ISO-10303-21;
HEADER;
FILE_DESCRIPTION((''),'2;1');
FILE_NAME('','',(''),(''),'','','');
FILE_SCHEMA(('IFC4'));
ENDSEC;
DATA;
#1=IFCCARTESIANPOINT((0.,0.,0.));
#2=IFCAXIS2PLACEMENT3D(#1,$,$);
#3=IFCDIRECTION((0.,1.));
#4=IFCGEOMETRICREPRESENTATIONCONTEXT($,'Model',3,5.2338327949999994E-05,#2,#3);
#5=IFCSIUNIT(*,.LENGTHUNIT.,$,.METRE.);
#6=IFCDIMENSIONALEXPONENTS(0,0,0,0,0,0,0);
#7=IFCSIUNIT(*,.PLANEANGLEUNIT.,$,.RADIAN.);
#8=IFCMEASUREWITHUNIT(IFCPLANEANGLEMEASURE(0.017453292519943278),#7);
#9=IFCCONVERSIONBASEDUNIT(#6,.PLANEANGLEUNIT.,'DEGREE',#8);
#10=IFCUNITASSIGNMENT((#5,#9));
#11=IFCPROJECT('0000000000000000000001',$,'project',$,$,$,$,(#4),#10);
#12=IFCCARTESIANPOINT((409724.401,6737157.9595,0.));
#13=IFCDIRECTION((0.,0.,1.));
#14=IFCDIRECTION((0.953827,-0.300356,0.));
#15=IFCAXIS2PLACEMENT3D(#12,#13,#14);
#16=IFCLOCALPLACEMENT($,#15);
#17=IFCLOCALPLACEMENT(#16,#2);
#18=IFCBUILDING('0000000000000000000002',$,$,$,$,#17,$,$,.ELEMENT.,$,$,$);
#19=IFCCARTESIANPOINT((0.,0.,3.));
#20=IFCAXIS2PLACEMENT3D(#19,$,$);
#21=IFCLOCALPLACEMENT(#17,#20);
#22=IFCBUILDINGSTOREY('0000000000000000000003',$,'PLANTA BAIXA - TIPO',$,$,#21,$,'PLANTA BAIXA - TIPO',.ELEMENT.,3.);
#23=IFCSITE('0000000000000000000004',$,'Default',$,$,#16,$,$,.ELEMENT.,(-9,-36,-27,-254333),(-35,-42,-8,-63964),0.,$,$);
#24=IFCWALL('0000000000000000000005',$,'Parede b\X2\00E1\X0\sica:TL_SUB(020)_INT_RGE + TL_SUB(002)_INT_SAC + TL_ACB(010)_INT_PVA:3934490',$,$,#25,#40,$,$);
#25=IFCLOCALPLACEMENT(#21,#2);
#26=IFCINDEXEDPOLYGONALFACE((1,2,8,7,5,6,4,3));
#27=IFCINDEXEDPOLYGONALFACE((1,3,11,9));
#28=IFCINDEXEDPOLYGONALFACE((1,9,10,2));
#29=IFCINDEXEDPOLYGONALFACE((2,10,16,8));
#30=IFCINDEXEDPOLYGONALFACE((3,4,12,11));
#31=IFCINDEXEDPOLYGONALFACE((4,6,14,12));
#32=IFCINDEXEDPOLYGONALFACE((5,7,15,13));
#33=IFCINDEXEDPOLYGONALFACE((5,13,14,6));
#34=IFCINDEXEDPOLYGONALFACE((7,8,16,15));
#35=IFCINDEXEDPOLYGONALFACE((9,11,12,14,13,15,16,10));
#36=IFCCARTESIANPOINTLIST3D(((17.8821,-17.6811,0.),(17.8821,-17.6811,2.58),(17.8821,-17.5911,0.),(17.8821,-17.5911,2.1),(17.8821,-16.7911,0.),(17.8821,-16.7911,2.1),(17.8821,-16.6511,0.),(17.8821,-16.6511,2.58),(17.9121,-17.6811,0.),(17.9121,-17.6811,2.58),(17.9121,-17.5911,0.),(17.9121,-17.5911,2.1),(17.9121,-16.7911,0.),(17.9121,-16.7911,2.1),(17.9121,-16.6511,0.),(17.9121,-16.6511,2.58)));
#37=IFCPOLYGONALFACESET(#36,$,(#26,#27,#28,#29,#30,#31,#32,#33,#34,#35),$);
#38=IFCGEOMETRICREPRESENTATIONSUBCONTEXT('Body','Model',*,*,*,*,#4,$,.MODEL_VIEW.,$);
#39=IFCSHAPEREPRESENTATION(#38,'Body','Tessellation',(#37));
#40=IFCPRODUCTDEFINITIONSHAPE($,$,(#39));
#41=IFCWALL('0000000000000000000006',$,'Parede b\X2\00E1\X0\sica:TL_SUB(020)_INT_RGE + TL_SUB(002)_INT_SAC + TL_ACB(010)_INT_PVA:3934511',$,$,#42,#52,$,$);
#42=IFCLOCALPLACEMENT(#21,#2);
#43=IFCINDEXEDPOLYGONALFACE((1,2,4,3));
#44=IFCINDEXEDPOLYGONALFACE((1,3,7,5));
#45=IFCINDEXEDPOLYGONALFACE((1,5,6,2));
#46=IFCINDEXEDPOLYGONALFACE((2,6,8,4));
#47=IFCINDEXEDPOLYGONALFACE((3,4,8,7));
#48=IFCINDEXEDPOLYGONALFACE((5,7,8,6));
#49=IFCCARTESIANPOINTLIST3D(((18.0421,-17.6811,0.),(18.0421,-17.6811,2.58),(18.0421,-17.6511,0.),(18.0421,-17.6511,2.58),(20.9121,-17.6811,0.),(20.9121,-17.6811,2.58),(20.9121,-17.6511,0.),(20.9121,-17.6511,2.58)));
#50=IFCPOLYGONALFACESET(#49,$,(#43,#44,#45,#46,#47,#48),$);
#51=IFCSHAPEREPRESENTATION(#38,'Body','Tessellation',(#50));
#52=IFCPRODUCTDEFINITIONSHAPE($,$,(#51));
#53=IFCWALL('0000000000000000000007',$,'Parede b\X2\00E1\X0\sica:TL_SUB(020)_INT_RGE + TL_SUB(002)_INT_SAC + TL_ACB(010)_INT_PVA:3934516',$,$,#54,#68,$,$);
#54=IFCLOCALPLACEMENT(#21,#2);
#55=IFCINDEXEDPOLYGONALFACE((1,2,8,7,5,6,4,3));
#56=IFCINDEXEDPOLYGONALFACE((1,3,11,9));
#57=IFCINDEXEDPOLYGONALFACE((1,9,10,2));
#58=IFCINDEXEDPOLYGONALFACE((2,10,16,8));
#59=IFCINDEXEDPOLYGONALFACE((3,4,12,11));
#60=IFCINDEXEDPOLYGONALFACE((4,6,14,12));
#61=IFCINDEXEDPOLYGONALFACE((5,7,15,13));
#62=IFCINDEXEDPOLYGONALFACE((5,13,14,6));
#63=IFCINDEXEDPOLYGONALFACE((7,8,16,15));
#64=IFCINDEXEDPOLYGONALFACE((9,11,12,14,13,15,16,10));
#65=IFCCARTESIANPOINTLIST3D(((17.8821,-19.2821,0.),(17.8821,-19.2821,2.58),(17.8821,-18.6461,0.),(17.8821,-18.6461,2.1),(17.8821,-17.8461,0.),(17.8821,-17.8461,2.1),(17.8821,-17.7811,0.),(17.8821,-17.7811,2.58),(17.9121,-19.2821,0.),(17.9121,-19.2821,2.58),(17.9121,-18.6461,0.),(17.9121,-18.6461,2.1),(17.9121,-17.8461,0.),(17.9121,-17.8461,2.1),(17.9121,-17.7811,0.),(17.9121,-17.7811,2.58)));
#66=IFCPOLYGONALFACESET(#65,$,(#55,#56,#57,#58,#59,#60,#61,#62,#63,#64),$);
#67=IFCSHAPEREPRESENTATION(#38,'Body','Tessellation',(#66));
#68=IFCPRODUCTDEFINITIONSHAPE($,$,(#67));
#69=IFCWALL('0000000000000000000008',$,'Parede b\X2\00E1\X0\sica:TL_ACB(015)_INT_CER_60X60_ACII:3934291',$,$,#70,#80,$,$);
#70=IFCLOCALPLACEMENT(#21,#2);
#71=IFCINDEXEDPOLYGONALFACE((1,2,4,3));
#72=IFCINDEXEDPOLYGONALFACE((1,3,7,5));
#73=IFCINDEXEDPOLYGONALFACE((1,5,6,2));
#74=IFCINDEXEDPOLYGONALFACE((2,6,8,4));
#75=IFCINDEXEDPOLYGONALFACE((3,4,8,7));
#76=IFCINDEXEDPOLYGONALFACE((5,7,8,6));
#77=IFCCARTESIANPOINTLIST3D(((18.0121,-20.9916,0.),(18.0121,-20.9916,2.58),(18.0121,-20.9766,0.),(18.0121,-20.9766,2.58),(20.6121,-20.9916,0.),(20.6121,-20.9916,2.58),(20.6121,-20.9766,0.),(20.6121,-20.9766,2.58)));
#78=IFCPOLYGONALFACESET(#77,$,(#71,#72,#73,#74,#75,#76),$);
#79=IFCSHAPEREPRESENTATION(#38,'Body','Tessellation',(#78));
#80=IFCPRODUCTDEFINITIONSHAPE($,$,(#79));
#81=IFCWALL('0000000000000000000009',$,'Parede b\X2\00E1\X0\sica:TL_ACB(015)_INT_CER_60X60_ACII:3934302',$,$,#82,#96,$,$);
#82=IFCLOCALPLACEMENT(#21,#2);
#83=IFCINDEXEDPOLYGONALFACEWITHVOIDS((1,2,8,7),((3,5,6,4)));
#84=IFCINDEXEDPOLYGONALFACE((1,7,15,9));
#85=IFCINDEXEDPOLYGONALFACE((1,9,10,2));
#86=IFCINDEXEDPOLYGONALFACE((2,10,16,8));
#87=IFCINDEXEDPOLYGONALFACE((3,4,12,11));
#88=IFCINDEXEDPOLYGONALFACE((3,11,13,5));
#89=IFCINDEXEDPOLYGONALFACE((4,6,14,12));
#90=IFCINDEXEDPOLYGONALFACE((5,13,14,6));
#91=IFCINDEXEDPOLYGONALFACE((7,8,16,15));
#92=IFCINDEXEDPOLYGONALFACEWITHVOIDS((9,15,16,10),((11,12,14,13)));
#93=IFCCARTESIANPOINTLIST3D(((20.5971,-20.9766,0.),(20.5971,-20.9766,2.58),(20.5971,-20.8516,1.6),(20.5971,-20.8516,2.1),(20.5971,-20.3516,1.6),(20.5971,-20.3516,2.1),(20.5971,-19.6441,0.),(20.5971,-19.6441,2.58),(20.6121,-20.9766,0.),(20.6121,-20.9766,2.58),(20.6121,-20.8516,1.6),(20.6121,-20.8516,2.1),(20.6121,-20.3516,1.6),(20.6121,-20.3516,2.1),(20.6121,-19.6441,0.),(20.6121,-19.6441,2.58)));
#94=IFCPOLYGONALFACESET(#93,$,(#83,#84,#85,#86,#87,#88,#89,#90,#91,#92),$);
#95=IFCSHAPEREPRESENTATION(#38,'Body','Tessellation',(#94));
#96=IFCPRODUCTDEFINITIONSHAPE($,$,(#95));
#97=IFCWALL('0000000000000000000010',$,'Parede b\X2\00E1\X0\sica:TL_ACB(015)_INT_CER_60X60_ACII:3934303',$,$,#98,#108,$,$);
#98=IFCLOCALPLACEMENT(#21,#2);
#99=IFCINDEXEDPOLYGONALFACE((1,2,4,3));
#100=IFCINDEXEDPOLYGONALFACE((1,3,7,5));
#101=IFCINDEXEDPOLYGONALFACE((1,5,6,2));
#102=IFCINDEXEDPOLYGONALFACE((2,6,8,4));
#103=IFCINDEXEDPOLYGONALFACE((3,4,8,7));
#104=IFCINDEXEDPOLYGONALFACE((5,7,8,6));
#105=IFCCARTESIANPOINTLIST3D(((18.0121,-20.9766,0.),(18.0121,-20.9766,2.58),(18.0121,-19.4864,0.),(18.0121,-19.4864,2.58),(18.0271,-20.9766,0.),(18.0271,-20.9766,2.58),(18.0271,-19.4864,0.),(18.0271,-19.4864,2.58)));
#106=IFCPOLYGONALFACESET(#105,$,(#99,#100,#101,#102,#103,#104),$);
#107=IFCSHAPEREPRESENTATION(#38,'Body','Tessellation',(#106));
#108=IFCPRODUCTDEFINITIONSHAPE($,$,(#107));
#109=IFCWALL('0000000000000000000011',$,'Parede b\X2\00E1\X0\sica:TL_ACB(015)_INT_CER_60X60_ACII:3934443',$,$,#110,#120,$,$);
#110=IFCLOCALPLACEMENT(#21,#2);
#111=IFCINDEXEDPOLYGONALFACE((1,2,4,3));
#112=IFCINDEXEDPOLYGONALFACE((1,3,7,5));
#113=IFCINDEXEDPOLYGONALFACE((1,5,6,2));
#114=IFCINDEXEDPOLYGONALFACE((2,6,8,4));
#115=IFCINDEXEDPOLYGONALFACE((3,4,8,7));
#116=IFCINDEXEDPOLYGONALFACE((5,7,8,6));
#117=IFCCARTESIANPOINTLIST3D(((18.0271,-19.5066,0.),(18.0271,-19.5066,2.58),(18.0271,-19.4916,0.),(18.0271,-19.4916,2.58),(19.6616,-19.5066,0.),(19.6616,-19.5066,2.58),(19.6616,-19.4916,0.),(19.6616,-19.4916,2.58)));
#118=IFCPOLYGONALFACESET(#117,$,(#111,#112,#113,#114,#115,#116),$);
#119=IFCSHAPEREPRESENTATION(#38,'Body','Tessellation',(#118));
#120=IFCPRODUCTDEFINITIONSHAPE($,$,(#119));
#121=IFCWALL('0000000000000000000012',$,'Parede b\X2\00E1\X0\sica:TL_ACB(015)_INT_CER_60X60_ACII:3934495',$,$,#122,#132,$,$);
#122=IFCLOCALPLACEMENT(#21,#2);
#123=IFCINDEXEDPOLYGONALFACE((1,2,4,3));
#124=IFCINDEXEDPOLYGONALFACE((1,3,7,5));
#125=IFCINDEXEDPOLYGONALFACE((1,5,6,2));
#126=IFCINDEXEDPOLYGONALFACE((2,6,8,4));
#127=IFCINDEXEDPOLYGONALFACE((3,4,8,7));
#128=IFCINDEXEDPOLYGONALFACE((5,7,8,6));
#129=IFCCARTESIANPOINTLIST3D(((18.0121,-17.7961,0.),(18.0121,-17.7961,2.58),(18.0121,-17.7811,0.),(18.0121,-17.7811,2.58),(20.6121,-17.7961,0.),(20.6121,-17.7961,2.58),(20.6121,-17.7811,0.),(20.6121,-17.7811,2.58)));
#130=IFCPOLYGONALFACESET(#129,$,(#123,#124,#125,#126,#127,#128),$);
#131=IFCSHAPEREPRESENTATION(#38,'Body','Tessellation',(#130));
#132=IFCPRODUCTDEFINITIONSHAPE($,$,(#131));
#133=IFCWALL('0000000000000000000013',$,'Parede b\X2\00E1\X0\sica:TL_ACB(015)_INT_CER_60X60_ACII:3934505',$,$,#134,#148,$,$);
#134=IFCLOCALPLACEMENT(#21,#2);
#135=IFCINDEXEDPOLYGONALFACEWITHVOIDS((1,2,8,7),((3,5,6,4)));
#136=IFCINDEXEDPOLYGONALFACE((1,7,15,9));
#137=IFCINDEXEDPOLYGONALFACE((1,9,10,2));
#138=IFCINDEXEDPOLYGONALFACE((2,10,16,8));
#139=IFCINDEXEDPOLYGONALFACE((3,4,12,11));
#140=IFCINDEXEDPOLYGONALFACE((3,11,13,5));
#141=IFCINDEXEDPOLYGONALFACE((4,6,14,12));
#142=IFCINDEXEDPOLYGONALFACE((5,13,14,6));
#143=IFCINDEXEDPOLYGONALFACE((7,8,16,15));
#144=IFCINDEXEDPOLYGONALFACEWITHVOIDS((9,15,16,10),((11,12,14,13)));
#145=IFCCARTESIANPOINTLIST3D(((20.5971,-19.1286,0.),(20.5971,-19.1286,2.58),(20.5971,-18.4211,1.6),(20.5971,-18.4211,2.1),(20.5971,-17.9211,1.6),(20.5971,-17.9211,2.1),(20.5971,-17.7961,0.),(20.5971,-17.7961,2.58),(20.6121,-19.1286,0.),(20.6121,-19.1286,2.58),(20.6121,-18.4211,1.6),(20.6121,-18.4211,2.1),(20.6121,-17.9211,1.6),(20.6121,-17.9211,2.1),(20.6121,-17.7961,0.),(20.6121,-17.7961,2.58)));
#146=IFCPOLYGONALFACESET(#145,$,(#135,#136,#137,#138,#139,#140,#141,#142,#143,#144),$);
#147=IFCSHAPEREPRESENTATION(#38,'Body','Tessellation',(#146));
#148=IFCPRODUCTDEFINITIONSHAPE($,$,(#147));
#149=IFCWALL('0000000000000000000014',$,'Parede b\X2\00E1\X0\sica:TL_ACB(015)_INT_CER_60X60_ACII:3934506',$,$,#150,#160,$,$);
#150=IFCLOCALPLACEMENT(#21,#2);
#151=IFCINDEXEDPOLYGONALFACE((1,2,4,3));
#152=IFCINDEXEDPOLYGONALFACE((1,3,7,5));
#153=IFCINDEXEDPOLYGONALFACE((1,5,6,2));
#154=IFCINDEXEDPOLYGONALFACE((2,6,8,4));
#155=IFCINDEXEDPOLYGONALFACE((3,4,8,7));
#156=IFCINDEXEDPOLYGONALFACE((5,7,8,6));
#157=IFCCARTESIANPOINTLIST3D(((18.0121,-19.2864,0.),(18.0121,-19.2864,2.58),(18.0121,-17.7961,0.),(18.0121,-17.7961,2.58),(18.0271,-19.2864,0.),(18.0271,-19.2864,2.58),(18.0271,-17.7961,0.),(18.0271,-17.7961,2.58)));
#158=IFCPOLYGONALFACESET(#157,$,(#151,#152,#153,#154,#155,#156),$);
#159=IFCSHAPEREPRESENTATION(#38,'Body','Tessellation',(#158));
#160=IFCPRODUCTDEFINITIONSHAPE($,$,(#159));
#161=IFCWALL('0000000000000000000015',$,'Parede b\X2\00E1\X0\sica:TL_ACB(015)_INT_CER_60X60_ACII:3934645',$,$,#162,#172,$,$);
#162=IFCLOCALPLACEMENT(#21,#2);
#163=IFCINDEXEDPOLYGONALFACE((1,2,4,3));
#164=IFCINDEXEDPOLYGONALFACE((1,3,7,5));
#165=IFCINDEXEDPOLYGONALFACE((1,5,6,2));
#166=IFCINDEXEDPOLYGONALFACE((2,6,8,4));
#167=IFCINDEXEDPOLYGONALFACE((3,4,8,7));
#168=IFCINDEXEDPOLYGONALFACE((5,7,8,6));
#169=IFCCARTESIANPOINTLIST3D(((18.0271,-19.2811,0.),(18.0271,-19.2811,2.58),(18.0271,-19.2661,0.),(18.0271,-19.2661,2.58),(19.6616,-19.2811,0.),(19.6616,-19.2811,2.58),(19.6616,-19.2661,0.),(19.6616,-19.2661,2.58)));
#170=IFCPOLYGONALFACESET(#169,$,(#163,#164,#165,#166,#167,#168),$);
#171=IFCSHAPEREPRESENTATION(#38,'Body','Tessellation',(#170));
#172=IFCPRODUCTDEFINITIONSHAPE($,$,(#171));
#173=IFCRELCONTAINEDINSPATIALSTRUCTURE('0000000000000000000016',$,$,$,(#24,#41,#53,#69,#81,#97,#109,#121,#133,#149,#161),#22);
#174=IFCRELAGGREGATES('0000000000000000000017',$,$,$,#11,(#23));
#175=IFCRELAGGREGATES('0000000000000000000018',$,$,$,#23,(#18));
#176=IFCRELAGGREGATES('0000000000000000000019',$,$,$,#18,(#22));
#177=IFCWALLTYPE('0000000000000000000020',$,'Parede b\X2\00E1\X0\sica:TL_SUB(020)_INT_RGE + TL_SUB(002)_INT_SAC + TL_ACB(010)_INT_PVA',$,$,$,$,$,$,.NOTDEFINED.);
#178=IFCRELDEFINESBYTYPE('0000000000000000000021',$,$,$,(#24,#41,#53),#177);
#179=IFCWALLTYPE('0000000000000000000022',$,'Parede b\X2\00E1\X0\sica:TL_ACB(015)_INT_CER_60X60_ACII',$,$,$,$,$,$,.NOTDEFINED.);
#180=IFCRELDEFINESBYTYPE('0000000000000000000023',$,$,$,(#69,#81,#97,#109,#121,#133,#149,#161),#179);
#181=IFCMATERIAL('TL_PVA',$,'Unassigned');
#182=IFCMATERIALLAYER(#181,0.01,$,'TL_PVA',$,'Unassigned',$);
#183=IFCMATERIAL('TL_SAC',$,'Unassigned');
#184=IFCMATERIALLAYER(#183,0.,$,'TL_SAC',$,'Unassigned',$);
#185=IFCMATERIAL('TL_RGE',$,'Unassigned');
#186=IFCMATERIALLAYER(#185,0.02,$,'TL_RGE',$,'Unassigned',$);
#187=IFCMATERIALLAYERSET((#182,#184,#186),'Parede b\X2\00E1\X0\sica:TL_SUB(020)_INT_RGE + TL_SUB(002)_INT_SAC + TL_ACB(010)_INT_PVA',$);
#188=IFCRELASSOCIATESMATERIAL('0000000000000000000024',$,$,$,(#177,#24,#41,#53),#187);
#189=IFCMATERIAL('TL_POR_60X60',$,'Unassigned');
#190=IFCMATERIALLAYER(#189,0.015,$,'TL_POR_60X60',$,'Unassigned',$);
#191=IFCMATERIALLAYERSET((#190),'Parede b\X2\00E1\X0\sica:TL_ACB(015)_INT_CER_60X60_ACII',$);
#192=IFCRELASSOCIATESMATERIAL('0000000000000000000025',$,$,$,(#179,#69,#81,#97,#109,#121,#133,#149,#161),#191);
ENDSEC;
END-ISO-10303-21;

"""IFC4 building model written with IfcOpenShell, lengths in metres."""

from ifc_helpers import new_model, entity, si_unit, converted_unit, direction, frame, frame_2d, origin, place, context, subcontext, project, spatial, rectangle, extrude, material, layer, layer_set, layer_usage, type_object, element, save


model = new_model("IFC4")

# Units and contexts
model_context = context("Model", 3, precision=5.2338327949999994e-05, world=origin(), true_north=direction((0.0, 1.0)))
body_context = subcontext(model_context, "Body", "Model", "MODEL_VIEW")
ifc_project = project(units=[si_unit("LENGTHUNIT", "METRE"), converted_unit("PLANEANGLEUNIT", "DEGREE", entity("IfcPlaneAngleMeasure", 0.017453292519943278), si_unit("PLANEANGLEUNIT", "RADIAN"), dimensions=[0, 0, 0, 0, 0, 0, 0])], contexts=[model_context])

# Site, building, storey
site_placement = place(None, frame((409724.401, 6737157.9595, 0.0), z_axis=(0.0, 0.0, 1.0), x_axis=(0.953827, -0.300356, 0.0)))
site = spatial("IfcSite", under=ifc_project, at=site_placement, Name="Default", CompositionType="ELEMENT", RefLatitude=(-9, -36, -27, -254333), RefLongitude=(-35, -42, -8, -63964), RefElevation=0.0)
building_placement = place(site_placement, origin())
building = spatial("IfcBuilding", under=site, at=building_placement, CompositionType="ELEMENT")
storey_placement = place(building_placement, frame((0.0, 0.0, 3.0)))
storey = spatial("IfcBuildingStorey", under=building, at=storey_placement, Name="PLANTA BAIXA - TIPO", LongName="PLANTA BAIXA - TIPO", CompositionType="ELEMENT", Elevation=3.0)

# Wall, opening
ifc_material_1 = material(Name="TL_PVA", Category="Unassigned")
ifc_layer_1 = layer(ifc_material_1, 0.01, Name="TL_PVA", Category="Unassigned")
ifc_material_2 = material(Name="TL_SAC", Category="Unassigned")
ifc_layer_2 = layer(ifc_material_2, 0.0, Name="TL_SAC", Category="Unassigned")
ifc_material_3 = material(Name="TL_RGE", Category="Unassigned")
ifc_layer_3 = layer(ifc_material_3, 0.02, Name="TL_RGE", Category="Unassigned")
ifc_layer_set_1 = layer_set([ifc_layer_1, ifc_layer_2, ifc_layer_3], Name="Parede básica:TL_SUB(020)_INT_RGE + TL_SUB(002)_INT_SAC + TL_ACB(010)_INT_PVA")
ifc_layer_usage_1 = layer_usage(ifc_layer_set_1, "AXIS2", "NEGATIVE", 0.015)
wall_type_1 = type_object("IfcWallType", Name="Parede básica:TL_SUB(020)_INT_RGE + TL_SUB(002)_INT_SAC + TL_ACB(010)_INT_PVA", PredefinedType="NOTDEFINED", material=ifc_layer_set_1)
wall_1_placement = place(storey_placement, frame((17.8971, -17.6811, 0.0), z_axis=(0.0, 0.0, 1.0), x_axis=(0.0, 1.0, 0.0)))
wall_1 = element("IfcWall", 1, at=wall_1_placement, inside=storey, type_object=wall_type_1, material=ifc_layer_usage_1, Name="Parede básica:TL_SUB(020)_INT_RGE + TL_SUB(002)_INT_SAC + TL_ACB(010)_INT_PVA:3934490", context=body_context, shape_type="SweptSolid", body=[
    extrude(rectangle(XDim=1.03, YDim=0.03, at=frame_2d((0.515, 0.0), x_axis=(-1.0, 0.0))), origin(), (0.0, 0.0, 1.0), 2.58),
])
opening_1_placement = place(wall_1_placement, frame((17.6811, 17.8971, 0.0)))
element("IfcOpeningElement", 2, at=opening_1_placement, cuts=wall_1, PredefinedType="OPENING", context=body_context, shape_type="SweptSolid", body=[
    extrude(rectangle(XDim=2.1, YDim=0.8, at=frame_2d((0.0, 0.0), x_axis=(1.0, 0.0))), frame((-17.1911, -19.4361, 1.05), z_axis=(0.0, 1.0, 0.0), x_axis=(0.0, 0.0, 1.0)), (0.0, 0.0, 1.0), 3.048),
])

# Wall
ifc_layer_usage_2 = layer_usage(ifc_layer_set_1, "AXIS2", "POSITIVE", -0.015)
wall_2_placement = place(storey_placement, frame((20.9121, -17.6661, 0.0), z_axis=(0.0, 0.0, 1.0), x_axis=(-1.0, 0.0, 0.0)))
element("IfcWall", 3, at=wall_2_placement, inside=storey, type_object=wall_type_1, material=ifc_layer_usage_2, Name="Parede básica:TL_SUB(020)_INT_RGE + TL_SUB(002)_INT_SAC + TL_ACB(010)_INT_PVA:3934511", context=body_context, shape_type="SweptSolid", body=[
    extrude(rectangle(XDim=2.87, YDim=0.03, at=frame_2d((1.435, 0.0), x_axis=(-1.0, 0.0))), origin(), (0.0, 0.0, 1.0), 2.58),
])

# Wall, opening
ifc_layer_usage_3 = layer_usage(ifc_layer_set_1, "AXIS2", "POSITIVE", -0.015)
wall_3_placement = place(storey_placement, frame((17.8971, -17.7811, 0.0), z_axis=(0.0, 0.0, 1.0), x_axis=(0.0, -1.0, 0.0)))
wall_3 = element("IfcWall", 4, at=wall_3_placement, inside=storey, type_object=wall_type_1, material=ifc_layer_usage_3, Name="Parede básica:TL_SUB(020)_INT_RGE + TL_SUB(002)_INT_SAC + TL_ACB(010)_INT_PVA:3934516", context=body_context, shape_type="SweptSolid", body=[
    extrude(rectangle(XDim=1.501, YDim=0.03, at=frame_2d((0.7505, 0.0), x_axis=(-1.0, 0.0))), origin(), (0.0, 0.0, 1.0), 2.58),
])
opening_2_placement = place(wall_3_placement, frame((0.065, -0.015, 0.0)))
element("IfcOpeningElement", 5, at=opening_2_placement, cuts=wall_3, PredefinedType="OPENING", context=body_context, shape_type="SweptSolid", body=[
    extrude(rectangle(XDim=2.1, YDim=0.8, at=frame_2d((1.05, 0.4), x_axis=(1.0, 0.0))), frame((0.0, 0.0, 0.0), z_axis=(0.0, 1.0, 0.0), x_axis=(0.0, 0.0, 1.0)), (0.0, 0.0, 1.0), 0.03),
])

# Wall
ifc_material_4 = material(Name="TL_POR_60X60", Category="Unassigned")
ifc_layer_4 = layer(ifc_material_4, 0.015, Name="TL_POR_60X60", Category="Unassigned")
ifc_layer_set_2 = layer_set([ifc_layer_4], Name="Parede básica:TL_ACB(015)_INT_CER_60X60_ACII")
ifc_layer_usage_4 = layer_usage(ifc_layer_set_2, "AXIS2", "POSITIVE", -0.0075)
wall_type_2 = type_object("IfcWallType", Name="Parede básica:TL_ACB(015)_INT_CER_60X60_ACII", PredefinedType="NOTDEFINED", material=ifc_layer_set_2)
wall_4_placement = place(storey_placement, frame((20.6121, -20.9841, 0.0), z_axis=(0.0, 0.0, 1.0), x_axis=(-1.0, 0.0, 0.0)))
element("IfcWall", 6, at=wall_4_placement, inside=storey, type_object=wall_type_2, material=ifc_layer_usage_4, Name="Parede básica:TL_ACB(015)_INT_CER_60X60_ACII:3934291", context=body_context, shape_type="SweptSolid", body=[
    extrude(rectangle(XDim=2.6, YDim=0.015, at=frame_2d((1.3, 0.0), x_axis=(-1.0, 0.0))), origin(), (0.0, 0.0, 1.0), 2.58),
])

# Wall, opening
ifc_layer_usage_5 = layer_usage(ifc_layer_set_2, "AXIS2", "NEGATIVE", 0.0075)
wall_5_placement = place(storey_placement, frame((20.6046, -20.9766, 0.0), z_axis=(0.0, 0.0, 1.0), x_axis=(0.0, 1.0, 0.0)))
wall_5 = element("IfcWall", 7, at=wall_5_placement, inside=storey, type_object=wall_type_2, material=ifc_layer_usage_5, Name="Parede básica:TL_ACB(015)_INT_CER_60X60_ACII:3934302", context=body_context, shape_type="SweptSolid", body=[
    extrude(rectangle(XDim=1.3325, YDim=0.015, at=frame_2d((0.6662, 0.0), x_axis=(-1.0, 0.0))), origin(), (0.0, 0.0, 1.0), 2.58),
])
opening_3_placement = place(wall_5_placement, frame((20.9766, 20.6046, 1.6)))
element("IfcOpeningElement", 8, at=opening_3_placement, cuts=wall_5, PredefinedType="OPENING", context=body_context, shape_type="SweptSolid", body=[
    extrude(rectangle(XDim=0.5, YDim=0.5, at=frame_2d((0.0, 0.0), x_axis=(1.0, 0.0))), frame((-20.6016, -22.2361, 0.25), z_axis=(0.0, 1.0, 0.0), x_axis=(0.0, 0.0, 1.0)), (0.0, 0.0, 1.0), 3.048),
])

# Walls
ifc_layer_usage_6 = layer_usage(ifc_layer_set_2, "AXIS2", "NEGATIVE", 0.0075)
wall_6_placement = place(storey_placement, frame((18.0196, -19.4864, 0.0), z_axis=(0.0, 0.0, 1.0), x_axis=(0.0, -1.0, 0.0)))
element("IfcWall", 9, at=wall_6_placement, inside=storey, type_object=wall_type_2, material=ifc_layer_usage_6, Name="Parede básica:TL_ACB(015)_INT_CER_60X60_ACII:3934303", context=body_context, shape_type="SweptSolid", body=[
    extrude(rectangle(XDim=1.4902, YDim=0.015, at=frame_2d((0.7451, 0.0), x_axis=(-1.0, 0.0))), origin(), (0.0, 0.0, 1.0), 2.58),
])
ifc_layer_usage_7 = layer_usage(ifc_layer_set_2, "AXIS2", "POSITIVE", -0.0075)
wall_7_placement = place(storey_placement, frame((18.0271, -19.4991, 0.0)))
element("IfcWall", 10, at=wall_7_placement, inside=storey, type_object=wall_type_2, material=ifc_layer_usage_7, Name="Parede básica:TL_ACB(015)_INT_CER_60X60_ACII:3934443", context=body_context, shape_type="SweptSolid", body=[
    extrude(rectangle(XDim=1.6345, YDim=0.015, at=frame_2d((0.8172, 0.0), x_axis=(-1.0, 0.0))), origin(), (0.0, 0.0, 1.0), 2.58),
])
ifc_layer_usage_8 = layer_usage(ifc_layer_set_2, "AXIS2", "NEGATIVE", 0.0075)
wall_8_placement = place(storey_placement, frame((20.6121, -17.7886, 0.0), z_axis=(0.0, 0.0, 1.0), x_axis=(-1.0, 0.0, 0.0)))
element("IfcWall", 11, at=wall_8_placement, inside=storey, type_object=wall_type_2, material=ifc_layer_usage_8, Name="Parede básica:TL_ACB(015)_INT_CER_60X60_ACII:3934495", context=body_context, shape_type="SweptSolid", body=[
    extrude(rectangle(XDim=2.6, YDim=0.015, at=frame_2d((1.3, 0.0), x_axis=(-1.0, 0.0))), origin(), (0.0, 0.0, 1.0), 2.58),
])

# Wall, opening
ifc_layer_usage_9 = layer_usage(ifc_layer_set_2, "AXIS2", "POSITIVE", -0.0075)
wall_9_placement = place(storey_placement, frame((20.6046, -17.7961, 0.0), z_axis=(0.0, 0.0, 1.0), x_axis=(0.0, -1.0, 0.0)))
wall_9 = element("IfcWall", 12, at=wall_9_placement, inside=storey, type_object=wall_type_2, material=ifc_layer_usage_9, Name="Parede básica:TL_ACB(015)_INT_CER_60X60_ACII:3934505", context=body_context, shape_type="SweptSolid", body=[
    extrude(rectangle(XDim=1.3325, YDim=0.015, at=frame_2d((0.6662, 0.0), x_axis=(-1.0, 0.0))), origin(), (0.0, 0.0, 1.0), 2.58),
])
opening_4_placement = place(wall_9_placement, frame((-17.7961, -20.6046, 1.6)))
element("IfcOpeningElement", 13, at=opening_4_placement, cuts=wall_9, PredefinedType="OPENING", context=body_context, shape_type="SweptSolid", body=[
    extrude(rectangle(XDim=0.5, YDim=0.5, at=frame_2d((0.0, 0.0), x_axis=(1.0, 0.0))), frame((18.1711, 19.1881, 0.25), z_axis=(0.0, 1.0, 0.0), x_axis=(0.0, 0.0, 1.0)), (0.0, 0.0, 1.0), 3.048),
])

# Walls
ifc_layer_usage_10 = layer_usage(ifc_layer_set_2, "AXIS2", "POSITIVE", -0.0075)
wall_10_placement = place(storey_placement, frame((18.0196, -19.2864, 0.0), z_axis=(0.0, 0.0, 1.0), x_axis=(0.0, 1.0, 0.0)))
element("IfcWall", 14, at=wall_10_placement, inside=storey, type_object=wall_type_2, material=ifc_layer_usage_10, Name="Parede básica:TL_ACB(015)_INT_CER_60X60_ACII:3934506", context=body_context, shape_type="SweptSolid", body=[
    extrude(rectangle(XDim=1.4902, YDim=0.015, at=frame_2d((0.7451, 0.0), x_axis=(-1.0, 0.0))), origin(), (0.0, 0.0, 1.0), 2.58),
])
ifc_layer_usage_11 = layer_usage(ifc_layer_set_2, "AXIS2", "NEGATIVE", 0.0075)
wall_11_placement = place(storey_placement, frame((18.0271, -19.2736, 0.0)))
element("IfcWall", 15, at=wall_11_placement, inside=storey, type_object=wall_type_2, material=ifc_layer_usage_11, Name="Parede básica:TL_ACB(015)_INT_CER_60X60_ACII:3934645", context=body_context, shape_type="SweptSolid", body=[
    extrude(rectangle(XDim=1.6345, YDim=0.015, at=frame_2d((0.8172, 0.0), x_axis=(-1.0, 0.0))), origin(), (0.0, 0.0, 1.0), 2.58),
])

save(model, "model.ifc")
